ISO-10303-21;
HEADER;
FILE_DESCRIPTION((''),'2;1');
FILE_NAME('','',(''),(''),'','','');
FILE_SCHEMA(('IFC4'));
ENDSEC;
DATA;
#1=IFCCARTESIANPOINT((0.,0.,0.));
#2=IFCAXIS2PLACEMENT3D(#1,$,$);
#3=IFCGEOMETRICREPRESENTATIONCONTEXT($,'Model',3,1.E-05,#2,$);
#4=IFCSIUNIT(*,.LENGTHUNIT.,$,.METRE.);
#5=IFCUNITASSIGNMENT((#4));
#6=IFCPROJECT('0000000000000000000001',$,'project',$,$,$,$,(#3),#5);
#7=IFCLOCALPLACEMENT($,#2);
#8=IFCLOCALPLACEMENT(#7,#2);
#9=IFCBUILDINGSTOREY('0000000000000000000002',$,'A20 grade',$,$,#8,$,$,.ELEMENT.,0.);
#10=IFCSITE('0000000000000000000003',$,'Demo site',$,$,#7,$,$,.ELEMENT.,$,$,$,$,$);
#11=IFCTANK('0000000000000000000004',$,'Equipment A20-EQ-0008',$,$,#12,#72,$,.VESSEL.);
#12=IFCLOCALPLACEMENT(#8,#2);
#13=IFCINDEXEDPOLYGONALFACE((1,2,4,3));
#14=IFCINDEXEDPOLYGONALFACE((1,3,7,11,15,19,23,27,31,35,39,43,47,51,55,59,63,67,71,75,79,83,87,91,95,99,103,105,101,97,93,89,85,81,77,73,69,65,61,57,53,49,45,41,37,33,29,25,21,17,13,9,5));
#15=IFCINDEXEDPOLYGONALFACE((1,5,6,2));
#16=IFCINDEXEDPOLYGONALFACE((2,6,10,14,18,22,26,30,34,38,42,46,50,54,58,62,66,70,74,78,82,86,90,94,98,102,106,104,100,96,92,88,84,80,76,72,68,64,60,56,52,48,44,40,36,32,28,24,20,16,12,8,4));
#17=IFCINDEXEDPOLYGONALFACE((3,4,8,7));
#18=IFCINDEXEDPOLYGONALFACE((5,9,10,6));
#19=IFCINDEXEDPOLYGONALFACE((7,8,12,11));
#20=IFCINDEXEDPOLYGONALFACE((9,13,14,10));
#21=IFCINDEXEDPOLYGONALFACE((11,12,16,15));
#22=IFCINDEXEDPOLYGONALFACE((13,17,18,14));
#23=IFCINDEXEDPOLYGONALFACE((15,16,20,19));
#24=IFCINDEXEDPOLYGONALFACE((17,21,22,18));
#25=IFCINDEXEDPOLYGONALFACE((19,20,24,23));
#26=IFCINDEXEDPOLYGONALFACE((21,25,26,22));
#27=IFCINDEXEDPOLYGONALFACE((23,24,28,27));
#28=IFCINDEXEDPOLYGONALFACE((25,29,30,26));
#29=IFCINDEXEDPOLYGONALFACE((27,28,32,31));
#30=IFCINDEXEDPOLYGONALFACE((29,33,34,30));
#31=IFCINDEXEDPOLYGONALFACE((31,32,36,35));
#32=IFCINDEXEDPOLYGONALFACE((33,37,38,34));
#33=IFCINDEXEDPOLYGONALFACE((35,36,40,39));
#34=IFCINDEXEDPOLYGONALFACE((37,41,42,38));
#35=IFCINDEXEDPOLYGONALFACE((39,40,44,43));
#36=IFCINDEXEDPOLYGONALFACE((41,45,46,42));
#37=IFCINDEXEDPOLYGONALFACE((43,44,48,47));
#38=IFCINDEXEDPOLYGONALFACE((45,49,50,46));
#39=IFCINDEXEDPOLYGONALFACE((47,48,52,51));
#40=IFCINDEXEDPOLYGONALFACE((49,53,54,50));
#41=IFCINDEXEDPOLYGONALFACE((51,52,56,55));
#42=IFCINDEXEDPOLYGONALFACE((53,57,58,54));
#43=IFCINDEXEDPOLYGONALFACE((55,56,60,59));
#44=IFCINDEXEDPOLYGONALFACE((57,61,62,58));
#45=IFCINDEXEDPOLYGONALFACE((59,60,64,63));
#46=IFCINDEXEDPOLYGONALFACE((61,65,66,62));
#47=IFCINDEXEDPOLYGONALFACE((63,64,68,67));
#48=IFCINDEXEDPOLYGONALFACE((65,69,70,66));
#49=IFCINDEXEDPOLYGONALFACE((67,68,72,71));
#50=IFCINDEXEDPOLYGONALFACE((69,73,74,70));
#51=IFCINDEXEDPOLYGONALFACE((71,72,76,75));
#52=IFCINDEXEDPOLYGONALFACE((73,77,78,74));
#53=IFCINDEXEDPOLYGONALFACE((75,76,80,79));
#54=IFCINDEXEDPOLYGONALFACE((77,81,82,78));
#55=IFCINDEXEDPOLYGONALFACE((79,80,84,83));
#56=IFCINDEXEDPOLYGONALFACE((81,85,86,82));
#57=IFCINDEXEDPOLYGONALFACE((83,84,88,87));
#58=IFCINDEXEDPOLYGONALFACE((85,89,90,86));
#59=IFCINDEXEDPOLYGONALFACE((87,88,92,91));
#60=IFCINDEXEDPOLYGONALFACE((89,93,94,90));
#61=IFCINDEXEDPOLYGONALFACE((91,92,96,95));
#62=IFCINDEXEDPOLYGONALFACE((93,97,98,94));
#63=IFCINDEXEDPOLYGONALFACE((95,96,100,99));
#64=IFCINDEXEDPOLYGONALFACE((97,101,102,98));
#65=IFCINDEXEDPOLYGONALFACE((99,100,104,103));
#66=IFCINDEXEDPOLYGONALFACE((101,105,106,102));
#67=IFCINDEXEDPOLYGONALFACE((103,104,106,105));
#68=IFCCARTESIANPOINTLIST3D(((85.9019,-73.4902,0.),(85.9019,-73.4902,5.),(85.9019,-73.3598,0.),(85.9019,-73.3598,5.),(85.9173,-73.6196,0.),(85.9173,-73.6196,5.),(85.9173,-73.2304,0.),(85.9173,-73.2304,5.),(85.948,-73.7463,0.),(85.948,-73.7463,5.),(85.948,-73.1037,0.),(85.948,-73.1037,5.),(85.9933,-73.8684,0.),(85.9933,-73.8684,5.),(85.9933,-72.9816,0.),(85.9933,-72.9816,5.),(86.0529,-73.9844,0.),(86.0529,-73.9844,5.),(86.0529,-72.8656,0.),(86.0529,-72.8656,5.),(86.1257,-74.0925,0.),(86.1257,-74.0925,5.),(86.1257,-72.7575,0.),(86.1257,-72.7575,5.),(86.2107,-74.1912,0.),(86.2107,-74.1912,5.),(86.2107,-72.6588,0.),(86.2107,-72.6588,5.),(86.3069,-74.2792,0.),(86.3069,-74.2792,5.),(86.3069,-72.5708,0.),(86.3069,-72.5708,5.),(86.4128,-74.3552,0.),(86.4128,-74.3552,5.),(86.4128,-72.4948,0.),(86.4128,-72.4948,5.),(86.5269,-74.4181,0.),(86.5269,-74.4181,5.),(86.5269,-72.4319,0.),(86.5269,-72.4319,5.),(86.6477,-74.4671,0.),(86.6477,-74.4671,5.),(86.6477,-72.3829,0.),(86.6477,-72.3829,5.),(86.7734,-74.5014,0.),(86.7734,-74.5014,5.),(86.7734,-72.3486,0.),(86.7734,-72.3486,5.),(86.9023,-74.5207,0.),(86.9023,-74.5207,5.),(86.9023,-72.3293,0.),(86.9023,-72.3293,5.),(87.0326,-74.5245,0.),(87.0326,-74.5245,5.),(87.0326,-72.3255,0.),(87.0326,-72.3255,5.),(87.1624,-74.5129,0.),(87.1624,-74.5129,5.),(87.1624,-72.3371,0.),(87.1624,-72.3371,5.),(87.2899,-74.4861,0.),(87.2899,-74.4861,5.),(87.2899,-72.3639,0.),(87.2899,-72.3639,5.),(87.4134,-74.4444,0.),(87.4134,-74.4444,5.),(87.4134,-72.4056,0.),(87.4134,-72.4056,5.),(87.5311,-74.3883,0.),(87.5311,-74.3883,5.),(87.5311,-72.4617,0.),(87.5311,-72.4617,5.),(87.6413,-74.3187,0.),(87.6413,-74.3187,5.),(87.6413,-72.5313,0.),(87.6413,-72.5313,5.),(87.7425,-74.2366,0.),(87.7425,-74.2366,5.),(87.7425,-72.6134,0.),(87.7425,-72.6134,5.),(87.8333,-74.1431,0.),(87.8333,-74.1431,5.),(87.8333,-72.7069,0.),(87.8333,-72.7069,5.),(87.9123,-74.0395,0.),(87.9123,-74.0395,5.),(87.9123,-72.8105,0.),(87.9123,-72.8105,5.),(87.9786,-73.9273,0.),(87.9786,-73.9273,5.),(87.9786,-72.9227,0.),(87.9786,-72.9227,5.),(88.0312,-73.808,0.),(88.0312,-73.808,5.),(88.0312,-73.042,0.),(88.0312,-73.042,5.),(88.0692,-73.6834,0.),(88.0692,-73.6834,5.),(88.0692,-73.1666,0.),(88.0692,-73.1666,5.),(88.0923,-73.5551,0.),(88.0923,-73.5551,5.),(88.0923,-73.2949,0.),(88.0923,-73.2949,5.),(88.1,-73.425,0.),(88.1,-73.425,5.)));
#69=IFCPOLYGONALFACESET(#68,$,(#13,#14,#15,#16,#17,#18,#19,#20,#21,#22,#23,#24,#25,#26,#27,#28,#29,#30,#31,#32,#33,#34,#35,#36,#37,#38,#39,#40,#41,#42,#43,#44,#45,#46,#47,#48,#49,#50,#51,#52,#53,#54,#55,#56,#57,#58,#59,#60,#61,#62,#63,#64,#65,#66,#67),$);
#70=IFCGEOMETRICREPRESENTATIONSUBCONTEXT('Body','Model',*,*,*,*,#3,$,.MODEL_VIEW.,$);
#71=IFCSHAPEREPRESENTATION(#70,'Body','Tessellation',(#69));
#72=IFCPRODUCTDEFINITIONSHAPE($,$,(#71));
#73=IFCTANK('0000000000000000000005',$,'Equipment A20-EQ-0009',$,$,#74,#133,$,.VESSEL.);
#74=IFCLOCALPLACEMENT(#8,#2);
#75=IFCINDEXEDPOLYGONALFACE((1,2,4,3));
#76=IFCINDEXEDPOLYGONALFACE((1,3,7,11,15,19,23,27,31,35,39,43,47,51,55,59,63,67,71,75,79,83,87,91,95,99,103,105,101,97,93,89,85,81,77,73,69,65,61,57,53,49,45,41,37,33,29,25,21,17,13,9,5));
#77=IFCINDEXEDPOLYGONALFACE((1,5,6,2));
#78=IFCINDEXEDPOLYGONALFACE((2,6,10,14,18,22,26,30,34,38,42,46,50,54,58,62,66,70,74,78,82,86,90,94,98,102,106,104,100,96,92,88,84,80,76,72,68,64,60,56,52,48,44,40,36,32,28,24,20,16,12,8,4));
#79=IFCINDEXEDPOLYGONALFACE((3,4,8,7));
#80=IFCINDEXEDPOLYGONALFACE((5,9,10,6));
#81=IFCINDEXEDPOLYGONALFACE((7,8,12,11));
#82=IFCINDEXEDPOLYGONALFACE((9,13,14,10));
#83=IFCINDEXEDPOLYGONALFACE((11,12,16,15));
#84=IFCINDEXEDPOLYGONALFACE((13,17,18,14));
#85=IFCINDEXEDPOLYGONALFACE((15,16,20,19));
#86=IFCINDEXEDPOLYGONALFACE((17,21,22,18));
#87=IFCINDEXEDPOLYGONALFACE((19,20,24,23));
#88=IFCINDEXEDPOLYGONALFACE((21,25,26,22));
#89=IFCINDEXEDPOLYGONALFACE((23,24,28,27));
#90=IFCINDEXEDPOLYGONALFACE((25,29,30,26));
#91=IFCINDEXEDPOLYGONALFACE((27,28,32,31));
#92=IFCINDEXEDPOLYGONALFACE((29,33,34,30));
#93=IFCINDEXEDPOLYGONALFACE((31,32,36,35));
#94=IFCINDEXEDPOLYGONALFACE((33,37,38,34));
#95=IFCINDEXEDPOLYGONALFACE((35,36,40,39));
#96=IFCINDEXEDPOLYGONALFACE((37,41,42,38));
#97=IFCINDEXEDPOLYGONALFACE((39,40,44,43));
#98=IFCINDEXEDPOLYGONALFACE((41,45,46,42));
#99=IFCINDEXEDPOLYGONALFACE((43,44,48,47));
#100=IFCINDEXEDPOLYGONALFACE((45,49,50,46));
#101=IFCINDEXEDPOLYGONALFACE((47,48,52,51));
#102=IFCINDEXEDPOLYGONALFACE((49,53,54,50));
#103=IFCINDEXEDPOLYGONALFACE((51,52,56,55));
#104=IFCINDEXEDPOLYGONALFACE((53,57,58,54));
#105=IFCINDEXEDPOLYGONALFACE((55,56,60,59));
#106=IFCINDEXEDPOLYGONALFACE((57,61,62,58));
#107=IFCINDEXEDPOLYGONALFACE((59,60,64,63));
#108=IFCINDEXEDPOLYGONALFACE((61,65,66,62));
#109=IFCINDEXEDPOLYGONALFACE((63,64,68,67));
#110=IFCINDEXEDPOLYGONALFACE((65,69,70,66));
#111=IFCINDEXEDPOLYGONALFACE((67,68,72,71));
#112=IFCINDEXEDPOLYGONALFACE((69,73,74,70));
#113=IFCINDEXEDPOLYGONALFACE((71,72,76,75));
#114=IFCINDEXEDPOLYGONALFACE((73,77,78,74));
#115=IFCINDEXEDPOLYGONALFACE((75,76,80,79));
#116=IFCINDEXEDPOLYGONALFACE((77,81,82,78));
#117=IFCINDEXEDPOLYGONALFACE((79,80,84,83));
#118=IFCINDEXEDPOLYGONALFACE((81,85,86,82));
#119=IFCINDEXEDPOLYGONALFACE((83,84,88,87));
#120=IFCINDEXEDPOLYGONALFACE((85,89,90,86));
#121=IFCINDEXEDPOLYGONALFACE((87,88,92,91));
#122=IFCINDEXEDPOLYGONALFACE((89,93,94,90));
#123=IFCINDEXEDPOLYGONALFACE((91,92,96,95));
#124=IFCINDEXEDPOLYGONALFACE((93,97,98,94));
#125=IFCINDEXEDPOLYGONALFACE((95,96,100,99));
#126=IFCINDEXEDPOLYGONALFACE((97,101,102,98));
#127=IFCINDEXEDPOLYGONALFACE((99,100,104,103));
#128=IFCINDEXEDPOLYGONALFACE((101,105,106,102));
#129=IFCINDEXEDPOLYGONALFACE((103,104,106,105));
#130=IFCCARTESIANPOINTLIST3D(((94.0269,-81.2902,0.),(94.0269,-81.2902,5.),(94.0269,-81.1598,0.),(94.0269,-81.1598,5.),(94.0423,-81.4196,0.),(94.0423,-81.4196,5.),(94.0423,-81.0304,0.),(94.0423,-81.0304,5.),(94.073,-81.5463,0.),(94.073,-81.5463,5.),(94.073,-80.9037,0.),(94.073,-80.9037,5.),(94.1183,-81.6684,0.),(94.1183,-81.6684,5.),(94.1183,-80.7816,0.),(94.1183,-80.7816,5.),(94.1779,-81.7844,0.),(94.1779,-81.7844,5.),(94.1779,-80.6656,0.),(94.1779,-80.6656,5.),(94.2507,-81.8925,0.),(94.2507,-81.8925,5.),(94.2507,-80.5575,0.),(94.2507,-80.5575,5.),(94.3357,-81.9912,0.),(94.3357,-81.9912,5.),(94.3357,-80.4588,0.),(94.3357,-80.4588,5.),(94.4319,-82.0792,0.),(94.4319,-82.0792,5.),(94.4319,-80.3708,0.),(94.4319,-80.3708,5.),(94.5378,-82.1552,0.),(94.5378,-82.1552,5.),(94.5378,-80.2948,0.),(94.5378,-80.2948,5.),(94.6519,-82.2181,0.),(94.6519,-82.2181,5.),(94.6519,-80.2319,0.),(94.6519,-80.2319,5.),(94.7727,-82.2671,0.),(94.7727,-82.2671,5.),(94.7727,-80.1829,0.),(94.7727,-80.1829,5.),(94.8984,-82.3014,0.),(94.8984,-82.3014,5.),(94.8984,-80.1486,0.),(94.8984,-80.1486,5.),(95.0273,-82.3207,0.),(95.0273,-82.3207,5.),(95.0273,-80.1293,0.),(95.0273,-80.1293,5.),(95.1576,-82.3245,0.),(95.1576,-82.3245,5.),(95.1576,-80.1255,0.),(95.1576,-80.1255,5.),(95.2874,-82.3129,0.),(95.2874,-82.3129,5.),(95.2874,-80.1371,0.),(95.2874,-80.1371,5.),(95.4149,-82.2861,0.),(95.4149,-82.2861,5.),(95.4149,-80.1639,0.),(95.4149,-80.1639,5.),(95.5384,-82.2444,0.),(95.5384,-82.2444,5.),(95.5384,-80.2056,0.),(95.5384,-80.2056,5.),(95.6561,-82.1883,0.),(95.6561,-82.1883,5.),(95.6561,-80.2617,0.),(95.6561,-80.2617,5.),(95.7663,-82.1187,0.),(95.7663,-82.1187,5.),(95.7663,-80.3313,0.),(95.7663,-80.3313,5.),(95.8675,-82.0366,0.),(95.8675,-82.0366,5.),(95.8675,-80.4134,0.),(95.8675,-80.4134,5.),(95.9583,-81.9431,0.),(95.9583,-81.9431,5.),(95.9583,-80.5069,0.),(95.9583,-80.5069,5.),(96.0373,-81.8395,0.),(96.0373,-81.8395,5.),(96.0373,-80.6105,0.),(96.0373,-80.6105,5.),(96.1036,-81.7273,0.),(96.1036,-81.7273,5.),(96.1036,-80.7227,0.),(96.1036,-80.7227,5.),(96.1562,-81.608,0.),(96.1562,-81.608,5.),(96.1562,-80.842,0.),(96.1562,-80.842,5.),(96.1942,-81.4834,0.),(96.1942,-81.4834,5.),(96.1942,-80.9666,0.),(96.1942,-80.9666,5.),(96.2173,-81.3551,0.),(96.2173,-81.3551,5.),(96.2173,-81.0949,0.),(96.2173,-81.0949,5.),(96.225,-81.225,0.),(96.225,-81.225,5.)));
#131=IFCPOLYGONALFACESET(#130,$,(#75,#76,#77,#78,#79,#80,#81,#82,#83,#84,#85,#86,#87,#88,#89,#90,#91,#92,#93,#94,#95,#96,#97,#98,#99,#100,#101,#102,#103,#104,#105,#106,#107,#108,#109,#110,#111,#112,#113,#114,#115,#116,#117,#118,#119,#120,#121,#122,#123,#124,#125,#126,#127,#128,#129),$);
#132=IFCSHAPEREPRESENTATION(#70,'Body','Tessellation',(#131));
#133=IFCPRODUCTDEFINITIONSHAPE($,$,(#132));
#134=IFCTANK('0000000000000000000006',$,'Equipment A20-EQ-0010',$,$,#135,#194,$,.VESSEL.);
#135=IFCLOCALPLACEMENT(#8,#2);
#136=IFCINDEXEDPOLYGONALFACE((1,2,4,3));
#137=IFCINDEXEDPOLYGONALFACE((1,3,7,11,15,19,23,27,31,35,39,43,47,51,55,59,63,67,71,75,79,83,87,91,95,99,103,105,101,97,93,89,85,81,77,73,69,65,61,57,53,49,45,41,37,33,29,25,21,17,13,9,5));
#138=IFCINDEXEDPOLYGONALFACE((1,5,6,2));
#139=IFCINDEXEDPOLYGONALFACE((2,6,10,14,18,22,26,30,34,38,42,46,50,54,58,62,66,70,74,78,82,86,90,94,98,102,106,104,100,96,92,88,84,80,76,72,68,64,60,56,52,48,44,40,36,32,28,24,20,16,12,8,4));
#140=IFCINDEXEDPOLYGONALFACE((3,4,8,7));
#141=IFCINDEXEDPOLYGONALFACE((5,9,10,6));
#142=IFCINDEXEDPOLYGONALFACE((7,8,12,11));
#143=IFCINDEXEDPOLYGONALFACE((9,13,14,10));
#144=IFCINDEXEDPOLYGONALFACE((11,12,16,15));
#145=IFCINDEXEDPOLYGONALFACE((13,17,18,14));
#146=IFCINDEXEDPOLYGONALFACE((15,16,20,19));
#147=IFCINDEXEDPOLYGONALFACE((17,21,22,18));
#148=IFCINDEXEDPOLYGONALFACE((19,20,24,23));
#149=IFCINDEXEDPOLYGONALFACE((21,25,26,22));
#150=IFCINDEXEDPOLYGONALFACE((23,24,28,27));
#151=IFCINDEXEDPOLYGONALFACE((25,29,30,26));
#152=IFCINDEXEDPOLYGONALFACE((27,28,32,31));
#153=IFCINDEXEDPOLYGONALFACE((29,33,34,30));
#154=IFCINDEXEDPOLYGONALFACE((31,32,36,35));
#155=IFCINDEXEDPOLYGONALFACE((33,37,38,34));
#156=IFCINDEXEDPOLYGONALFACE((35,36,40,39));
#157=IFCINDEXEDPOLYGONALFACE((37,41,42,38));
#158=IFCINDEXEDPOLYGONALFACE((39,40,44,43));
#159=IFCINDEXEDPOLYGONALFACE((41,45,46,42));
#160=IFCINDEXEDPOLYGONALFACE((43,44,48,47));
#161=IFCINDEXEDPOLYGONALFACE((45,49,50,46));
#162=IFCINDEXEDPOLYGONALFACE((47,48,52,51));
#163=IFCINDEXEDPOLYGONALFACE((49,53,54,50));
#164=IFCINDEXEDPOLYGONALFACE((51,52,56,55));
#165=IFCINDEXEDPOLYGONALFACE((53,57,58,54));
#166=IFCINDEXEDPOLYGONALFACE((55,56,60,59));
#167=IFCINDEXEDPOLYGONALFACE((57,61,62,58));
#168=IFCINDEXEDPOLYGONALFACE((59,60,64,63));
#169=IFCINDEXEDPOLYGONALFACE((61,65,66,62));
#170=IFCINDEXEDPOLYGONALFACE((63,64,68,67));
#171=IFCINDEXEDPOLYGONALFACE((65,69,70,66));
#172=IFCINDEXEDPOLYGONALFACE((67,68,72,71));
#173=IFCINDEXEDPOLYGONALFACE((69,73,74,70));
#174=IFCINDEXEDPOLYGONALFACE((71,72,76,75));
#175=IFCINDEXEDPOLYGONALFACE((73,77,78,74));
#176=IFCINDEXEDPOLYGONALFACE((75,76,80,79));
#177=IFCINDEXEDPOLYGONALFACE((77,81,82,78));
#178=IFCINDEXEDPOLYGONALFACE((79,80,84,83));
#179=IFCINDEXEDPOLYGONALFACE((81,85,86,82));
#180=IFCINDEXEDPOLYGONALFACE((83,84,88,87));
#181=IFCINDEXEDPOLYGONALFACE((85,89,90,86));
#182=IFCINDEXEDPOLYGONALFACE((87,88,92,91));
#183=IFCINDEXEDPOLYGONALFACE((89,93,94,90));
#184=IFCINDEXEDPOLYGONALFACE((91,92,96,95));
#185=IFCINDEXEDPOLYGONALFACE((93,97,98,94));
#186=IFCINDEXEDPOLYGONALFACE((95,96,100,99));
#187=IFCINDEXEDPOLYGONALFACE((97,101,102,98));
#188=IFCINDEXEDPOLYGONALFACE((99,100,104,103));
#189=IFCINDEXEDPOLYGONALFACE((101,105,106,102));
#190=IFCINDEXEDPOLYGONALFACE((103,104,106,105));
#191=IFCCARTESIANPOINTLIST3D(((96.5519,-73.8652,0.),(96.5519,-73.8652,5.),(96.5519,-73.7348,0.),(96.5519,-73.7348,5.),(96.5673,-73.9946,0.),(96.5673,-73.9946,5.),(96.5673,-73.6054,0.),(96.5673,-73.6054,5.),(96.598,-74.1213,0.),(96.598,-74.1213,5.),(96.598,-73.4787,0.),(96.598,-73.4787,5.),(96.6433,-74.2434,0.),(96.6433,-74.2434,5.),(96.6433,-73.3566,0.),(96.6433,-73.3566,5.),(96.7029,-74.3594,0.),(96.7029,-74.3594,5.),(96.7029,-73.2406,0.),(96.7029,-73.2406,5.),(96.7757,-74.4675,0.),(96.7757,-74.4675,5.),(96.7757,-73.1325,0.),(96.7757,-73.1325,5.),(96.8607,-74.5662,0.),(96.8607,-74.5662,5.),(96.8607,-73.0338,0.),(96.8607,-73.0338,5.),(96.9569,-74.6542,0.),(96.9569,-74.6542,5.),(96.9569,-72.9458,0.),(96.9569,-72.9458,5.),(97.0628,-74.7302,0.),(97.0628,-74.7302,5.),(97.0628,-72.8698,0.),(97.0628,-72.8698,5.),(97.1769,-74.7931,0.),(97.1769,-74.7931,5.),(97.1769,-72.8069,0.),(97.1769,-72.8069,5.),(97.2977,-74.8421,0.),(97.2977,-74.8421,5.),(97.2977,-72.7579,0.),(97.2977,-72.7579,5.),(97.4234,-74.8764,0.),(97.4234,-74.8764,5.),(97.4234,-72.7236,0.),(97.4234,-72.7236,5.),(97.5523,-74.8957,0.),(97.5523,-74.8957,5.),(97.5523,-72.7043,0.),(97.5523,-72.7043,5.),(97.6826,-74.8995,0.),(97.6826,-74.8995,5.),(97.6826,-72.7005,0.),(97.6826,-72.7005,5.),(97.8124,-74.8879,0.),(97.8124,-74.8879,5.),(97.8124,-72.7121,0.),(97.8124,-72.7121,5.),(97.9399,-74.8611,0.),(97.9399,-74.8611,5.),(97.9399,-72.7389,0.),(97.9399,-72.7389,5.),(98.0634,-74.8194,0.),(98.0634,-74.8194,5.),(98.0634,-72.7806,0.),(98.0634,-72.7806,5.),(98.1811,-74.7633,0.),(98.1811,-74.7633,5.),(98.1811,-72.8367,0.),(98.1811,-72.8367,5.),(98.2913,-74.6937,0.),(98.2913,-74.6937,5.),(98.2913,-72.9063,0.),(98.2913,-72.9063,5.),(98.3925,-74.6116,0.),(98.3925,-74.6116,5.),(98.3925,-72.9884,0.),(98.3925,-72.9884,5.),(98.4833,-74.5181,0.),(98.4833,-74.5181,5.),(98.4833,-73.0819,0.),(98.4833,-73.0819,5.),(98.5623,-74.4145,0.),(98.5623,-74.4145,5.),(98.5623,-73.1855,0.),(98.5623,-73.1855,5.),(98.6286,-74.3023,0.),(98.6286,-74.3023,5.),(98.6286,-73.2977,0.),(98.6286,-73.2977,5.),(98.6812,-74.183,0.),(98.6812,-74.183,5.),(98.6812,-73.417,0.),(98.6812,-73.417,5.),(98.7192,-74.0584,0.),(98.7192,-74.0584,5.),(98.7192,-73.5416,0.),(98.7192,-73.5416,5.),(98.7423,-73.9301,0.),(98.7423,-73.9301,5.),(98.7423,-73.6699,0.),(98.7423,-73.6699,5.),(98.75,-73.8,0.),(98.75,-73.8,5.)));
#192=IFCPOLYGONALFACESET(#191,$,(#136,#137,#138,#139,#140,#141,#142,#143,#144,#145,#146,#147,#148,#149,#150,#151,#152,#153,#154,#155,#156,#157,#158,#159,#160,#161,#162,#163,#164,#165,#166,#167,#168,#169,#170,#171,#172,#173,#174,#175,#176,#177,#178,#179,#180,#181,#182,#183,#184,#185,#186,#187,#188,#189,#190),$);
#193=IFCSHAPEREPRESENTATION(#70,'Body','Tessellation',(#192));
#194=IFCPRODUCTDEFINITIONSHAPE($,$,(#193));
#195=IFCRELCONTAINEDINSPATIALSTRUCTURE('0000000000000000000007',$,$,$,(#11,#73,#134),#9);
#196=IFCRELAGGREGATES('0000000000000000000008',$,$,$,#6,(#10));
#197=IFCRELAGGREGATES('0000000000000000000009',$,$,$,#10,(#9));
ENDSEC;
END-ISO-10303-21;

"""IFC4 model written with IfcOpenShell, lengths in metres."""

from ifc_helpers import new_model, si_unit, frame, origin, place, context, subcontext, project, spatial, circle, extrude, element, save


model = new_model("IFC4")

# Units and contexts
model_context = context("Model", 3, precision=1e-05, world=origin())
body_context = subcontext(model_context, "Body", "Model", "MODEL_VIEW")
ifc_project = project(units=[si_unit("LENGTHUNIT", "METRE")], contexts=[model_context])

# Site, storey
site_placement = place(None, origin())
site = spatial("IfcSite", under=ifc_project, at=site_placement, Name="Demo site", CompositionType="ELEMENT")
storey_placement = place(site_placement, origin())
storey = spatial("IfcBuildingStorey", under=site, at=storey_placement, Name="A20 grade", CompositionType="ELEMENT", Elevation=0.0)

# Tanks
for number, where, name in (
    (1, (87.0, -73.425, 0.0), "Equipment A20-EQ-0008"),
    (2, (95.125, -81.225, 0.0), "Equipment A20-EQ-0009"),
    (3, (97.65, -73.8, 0.0), "Equipment A20-EQ-0010"),
):
    element("IfcTank", number, at=place(storey_placement, frame(where)), inside=storey, Name=name, PredefinedType="VESSEL", context=body_context, shape_type="SweptSolid", body=[
        extrude(circle(Radius=1.1), origin(), (0.0, 0.0, 1.0), 5.0),
    ])

save(model, "model.ifc")
